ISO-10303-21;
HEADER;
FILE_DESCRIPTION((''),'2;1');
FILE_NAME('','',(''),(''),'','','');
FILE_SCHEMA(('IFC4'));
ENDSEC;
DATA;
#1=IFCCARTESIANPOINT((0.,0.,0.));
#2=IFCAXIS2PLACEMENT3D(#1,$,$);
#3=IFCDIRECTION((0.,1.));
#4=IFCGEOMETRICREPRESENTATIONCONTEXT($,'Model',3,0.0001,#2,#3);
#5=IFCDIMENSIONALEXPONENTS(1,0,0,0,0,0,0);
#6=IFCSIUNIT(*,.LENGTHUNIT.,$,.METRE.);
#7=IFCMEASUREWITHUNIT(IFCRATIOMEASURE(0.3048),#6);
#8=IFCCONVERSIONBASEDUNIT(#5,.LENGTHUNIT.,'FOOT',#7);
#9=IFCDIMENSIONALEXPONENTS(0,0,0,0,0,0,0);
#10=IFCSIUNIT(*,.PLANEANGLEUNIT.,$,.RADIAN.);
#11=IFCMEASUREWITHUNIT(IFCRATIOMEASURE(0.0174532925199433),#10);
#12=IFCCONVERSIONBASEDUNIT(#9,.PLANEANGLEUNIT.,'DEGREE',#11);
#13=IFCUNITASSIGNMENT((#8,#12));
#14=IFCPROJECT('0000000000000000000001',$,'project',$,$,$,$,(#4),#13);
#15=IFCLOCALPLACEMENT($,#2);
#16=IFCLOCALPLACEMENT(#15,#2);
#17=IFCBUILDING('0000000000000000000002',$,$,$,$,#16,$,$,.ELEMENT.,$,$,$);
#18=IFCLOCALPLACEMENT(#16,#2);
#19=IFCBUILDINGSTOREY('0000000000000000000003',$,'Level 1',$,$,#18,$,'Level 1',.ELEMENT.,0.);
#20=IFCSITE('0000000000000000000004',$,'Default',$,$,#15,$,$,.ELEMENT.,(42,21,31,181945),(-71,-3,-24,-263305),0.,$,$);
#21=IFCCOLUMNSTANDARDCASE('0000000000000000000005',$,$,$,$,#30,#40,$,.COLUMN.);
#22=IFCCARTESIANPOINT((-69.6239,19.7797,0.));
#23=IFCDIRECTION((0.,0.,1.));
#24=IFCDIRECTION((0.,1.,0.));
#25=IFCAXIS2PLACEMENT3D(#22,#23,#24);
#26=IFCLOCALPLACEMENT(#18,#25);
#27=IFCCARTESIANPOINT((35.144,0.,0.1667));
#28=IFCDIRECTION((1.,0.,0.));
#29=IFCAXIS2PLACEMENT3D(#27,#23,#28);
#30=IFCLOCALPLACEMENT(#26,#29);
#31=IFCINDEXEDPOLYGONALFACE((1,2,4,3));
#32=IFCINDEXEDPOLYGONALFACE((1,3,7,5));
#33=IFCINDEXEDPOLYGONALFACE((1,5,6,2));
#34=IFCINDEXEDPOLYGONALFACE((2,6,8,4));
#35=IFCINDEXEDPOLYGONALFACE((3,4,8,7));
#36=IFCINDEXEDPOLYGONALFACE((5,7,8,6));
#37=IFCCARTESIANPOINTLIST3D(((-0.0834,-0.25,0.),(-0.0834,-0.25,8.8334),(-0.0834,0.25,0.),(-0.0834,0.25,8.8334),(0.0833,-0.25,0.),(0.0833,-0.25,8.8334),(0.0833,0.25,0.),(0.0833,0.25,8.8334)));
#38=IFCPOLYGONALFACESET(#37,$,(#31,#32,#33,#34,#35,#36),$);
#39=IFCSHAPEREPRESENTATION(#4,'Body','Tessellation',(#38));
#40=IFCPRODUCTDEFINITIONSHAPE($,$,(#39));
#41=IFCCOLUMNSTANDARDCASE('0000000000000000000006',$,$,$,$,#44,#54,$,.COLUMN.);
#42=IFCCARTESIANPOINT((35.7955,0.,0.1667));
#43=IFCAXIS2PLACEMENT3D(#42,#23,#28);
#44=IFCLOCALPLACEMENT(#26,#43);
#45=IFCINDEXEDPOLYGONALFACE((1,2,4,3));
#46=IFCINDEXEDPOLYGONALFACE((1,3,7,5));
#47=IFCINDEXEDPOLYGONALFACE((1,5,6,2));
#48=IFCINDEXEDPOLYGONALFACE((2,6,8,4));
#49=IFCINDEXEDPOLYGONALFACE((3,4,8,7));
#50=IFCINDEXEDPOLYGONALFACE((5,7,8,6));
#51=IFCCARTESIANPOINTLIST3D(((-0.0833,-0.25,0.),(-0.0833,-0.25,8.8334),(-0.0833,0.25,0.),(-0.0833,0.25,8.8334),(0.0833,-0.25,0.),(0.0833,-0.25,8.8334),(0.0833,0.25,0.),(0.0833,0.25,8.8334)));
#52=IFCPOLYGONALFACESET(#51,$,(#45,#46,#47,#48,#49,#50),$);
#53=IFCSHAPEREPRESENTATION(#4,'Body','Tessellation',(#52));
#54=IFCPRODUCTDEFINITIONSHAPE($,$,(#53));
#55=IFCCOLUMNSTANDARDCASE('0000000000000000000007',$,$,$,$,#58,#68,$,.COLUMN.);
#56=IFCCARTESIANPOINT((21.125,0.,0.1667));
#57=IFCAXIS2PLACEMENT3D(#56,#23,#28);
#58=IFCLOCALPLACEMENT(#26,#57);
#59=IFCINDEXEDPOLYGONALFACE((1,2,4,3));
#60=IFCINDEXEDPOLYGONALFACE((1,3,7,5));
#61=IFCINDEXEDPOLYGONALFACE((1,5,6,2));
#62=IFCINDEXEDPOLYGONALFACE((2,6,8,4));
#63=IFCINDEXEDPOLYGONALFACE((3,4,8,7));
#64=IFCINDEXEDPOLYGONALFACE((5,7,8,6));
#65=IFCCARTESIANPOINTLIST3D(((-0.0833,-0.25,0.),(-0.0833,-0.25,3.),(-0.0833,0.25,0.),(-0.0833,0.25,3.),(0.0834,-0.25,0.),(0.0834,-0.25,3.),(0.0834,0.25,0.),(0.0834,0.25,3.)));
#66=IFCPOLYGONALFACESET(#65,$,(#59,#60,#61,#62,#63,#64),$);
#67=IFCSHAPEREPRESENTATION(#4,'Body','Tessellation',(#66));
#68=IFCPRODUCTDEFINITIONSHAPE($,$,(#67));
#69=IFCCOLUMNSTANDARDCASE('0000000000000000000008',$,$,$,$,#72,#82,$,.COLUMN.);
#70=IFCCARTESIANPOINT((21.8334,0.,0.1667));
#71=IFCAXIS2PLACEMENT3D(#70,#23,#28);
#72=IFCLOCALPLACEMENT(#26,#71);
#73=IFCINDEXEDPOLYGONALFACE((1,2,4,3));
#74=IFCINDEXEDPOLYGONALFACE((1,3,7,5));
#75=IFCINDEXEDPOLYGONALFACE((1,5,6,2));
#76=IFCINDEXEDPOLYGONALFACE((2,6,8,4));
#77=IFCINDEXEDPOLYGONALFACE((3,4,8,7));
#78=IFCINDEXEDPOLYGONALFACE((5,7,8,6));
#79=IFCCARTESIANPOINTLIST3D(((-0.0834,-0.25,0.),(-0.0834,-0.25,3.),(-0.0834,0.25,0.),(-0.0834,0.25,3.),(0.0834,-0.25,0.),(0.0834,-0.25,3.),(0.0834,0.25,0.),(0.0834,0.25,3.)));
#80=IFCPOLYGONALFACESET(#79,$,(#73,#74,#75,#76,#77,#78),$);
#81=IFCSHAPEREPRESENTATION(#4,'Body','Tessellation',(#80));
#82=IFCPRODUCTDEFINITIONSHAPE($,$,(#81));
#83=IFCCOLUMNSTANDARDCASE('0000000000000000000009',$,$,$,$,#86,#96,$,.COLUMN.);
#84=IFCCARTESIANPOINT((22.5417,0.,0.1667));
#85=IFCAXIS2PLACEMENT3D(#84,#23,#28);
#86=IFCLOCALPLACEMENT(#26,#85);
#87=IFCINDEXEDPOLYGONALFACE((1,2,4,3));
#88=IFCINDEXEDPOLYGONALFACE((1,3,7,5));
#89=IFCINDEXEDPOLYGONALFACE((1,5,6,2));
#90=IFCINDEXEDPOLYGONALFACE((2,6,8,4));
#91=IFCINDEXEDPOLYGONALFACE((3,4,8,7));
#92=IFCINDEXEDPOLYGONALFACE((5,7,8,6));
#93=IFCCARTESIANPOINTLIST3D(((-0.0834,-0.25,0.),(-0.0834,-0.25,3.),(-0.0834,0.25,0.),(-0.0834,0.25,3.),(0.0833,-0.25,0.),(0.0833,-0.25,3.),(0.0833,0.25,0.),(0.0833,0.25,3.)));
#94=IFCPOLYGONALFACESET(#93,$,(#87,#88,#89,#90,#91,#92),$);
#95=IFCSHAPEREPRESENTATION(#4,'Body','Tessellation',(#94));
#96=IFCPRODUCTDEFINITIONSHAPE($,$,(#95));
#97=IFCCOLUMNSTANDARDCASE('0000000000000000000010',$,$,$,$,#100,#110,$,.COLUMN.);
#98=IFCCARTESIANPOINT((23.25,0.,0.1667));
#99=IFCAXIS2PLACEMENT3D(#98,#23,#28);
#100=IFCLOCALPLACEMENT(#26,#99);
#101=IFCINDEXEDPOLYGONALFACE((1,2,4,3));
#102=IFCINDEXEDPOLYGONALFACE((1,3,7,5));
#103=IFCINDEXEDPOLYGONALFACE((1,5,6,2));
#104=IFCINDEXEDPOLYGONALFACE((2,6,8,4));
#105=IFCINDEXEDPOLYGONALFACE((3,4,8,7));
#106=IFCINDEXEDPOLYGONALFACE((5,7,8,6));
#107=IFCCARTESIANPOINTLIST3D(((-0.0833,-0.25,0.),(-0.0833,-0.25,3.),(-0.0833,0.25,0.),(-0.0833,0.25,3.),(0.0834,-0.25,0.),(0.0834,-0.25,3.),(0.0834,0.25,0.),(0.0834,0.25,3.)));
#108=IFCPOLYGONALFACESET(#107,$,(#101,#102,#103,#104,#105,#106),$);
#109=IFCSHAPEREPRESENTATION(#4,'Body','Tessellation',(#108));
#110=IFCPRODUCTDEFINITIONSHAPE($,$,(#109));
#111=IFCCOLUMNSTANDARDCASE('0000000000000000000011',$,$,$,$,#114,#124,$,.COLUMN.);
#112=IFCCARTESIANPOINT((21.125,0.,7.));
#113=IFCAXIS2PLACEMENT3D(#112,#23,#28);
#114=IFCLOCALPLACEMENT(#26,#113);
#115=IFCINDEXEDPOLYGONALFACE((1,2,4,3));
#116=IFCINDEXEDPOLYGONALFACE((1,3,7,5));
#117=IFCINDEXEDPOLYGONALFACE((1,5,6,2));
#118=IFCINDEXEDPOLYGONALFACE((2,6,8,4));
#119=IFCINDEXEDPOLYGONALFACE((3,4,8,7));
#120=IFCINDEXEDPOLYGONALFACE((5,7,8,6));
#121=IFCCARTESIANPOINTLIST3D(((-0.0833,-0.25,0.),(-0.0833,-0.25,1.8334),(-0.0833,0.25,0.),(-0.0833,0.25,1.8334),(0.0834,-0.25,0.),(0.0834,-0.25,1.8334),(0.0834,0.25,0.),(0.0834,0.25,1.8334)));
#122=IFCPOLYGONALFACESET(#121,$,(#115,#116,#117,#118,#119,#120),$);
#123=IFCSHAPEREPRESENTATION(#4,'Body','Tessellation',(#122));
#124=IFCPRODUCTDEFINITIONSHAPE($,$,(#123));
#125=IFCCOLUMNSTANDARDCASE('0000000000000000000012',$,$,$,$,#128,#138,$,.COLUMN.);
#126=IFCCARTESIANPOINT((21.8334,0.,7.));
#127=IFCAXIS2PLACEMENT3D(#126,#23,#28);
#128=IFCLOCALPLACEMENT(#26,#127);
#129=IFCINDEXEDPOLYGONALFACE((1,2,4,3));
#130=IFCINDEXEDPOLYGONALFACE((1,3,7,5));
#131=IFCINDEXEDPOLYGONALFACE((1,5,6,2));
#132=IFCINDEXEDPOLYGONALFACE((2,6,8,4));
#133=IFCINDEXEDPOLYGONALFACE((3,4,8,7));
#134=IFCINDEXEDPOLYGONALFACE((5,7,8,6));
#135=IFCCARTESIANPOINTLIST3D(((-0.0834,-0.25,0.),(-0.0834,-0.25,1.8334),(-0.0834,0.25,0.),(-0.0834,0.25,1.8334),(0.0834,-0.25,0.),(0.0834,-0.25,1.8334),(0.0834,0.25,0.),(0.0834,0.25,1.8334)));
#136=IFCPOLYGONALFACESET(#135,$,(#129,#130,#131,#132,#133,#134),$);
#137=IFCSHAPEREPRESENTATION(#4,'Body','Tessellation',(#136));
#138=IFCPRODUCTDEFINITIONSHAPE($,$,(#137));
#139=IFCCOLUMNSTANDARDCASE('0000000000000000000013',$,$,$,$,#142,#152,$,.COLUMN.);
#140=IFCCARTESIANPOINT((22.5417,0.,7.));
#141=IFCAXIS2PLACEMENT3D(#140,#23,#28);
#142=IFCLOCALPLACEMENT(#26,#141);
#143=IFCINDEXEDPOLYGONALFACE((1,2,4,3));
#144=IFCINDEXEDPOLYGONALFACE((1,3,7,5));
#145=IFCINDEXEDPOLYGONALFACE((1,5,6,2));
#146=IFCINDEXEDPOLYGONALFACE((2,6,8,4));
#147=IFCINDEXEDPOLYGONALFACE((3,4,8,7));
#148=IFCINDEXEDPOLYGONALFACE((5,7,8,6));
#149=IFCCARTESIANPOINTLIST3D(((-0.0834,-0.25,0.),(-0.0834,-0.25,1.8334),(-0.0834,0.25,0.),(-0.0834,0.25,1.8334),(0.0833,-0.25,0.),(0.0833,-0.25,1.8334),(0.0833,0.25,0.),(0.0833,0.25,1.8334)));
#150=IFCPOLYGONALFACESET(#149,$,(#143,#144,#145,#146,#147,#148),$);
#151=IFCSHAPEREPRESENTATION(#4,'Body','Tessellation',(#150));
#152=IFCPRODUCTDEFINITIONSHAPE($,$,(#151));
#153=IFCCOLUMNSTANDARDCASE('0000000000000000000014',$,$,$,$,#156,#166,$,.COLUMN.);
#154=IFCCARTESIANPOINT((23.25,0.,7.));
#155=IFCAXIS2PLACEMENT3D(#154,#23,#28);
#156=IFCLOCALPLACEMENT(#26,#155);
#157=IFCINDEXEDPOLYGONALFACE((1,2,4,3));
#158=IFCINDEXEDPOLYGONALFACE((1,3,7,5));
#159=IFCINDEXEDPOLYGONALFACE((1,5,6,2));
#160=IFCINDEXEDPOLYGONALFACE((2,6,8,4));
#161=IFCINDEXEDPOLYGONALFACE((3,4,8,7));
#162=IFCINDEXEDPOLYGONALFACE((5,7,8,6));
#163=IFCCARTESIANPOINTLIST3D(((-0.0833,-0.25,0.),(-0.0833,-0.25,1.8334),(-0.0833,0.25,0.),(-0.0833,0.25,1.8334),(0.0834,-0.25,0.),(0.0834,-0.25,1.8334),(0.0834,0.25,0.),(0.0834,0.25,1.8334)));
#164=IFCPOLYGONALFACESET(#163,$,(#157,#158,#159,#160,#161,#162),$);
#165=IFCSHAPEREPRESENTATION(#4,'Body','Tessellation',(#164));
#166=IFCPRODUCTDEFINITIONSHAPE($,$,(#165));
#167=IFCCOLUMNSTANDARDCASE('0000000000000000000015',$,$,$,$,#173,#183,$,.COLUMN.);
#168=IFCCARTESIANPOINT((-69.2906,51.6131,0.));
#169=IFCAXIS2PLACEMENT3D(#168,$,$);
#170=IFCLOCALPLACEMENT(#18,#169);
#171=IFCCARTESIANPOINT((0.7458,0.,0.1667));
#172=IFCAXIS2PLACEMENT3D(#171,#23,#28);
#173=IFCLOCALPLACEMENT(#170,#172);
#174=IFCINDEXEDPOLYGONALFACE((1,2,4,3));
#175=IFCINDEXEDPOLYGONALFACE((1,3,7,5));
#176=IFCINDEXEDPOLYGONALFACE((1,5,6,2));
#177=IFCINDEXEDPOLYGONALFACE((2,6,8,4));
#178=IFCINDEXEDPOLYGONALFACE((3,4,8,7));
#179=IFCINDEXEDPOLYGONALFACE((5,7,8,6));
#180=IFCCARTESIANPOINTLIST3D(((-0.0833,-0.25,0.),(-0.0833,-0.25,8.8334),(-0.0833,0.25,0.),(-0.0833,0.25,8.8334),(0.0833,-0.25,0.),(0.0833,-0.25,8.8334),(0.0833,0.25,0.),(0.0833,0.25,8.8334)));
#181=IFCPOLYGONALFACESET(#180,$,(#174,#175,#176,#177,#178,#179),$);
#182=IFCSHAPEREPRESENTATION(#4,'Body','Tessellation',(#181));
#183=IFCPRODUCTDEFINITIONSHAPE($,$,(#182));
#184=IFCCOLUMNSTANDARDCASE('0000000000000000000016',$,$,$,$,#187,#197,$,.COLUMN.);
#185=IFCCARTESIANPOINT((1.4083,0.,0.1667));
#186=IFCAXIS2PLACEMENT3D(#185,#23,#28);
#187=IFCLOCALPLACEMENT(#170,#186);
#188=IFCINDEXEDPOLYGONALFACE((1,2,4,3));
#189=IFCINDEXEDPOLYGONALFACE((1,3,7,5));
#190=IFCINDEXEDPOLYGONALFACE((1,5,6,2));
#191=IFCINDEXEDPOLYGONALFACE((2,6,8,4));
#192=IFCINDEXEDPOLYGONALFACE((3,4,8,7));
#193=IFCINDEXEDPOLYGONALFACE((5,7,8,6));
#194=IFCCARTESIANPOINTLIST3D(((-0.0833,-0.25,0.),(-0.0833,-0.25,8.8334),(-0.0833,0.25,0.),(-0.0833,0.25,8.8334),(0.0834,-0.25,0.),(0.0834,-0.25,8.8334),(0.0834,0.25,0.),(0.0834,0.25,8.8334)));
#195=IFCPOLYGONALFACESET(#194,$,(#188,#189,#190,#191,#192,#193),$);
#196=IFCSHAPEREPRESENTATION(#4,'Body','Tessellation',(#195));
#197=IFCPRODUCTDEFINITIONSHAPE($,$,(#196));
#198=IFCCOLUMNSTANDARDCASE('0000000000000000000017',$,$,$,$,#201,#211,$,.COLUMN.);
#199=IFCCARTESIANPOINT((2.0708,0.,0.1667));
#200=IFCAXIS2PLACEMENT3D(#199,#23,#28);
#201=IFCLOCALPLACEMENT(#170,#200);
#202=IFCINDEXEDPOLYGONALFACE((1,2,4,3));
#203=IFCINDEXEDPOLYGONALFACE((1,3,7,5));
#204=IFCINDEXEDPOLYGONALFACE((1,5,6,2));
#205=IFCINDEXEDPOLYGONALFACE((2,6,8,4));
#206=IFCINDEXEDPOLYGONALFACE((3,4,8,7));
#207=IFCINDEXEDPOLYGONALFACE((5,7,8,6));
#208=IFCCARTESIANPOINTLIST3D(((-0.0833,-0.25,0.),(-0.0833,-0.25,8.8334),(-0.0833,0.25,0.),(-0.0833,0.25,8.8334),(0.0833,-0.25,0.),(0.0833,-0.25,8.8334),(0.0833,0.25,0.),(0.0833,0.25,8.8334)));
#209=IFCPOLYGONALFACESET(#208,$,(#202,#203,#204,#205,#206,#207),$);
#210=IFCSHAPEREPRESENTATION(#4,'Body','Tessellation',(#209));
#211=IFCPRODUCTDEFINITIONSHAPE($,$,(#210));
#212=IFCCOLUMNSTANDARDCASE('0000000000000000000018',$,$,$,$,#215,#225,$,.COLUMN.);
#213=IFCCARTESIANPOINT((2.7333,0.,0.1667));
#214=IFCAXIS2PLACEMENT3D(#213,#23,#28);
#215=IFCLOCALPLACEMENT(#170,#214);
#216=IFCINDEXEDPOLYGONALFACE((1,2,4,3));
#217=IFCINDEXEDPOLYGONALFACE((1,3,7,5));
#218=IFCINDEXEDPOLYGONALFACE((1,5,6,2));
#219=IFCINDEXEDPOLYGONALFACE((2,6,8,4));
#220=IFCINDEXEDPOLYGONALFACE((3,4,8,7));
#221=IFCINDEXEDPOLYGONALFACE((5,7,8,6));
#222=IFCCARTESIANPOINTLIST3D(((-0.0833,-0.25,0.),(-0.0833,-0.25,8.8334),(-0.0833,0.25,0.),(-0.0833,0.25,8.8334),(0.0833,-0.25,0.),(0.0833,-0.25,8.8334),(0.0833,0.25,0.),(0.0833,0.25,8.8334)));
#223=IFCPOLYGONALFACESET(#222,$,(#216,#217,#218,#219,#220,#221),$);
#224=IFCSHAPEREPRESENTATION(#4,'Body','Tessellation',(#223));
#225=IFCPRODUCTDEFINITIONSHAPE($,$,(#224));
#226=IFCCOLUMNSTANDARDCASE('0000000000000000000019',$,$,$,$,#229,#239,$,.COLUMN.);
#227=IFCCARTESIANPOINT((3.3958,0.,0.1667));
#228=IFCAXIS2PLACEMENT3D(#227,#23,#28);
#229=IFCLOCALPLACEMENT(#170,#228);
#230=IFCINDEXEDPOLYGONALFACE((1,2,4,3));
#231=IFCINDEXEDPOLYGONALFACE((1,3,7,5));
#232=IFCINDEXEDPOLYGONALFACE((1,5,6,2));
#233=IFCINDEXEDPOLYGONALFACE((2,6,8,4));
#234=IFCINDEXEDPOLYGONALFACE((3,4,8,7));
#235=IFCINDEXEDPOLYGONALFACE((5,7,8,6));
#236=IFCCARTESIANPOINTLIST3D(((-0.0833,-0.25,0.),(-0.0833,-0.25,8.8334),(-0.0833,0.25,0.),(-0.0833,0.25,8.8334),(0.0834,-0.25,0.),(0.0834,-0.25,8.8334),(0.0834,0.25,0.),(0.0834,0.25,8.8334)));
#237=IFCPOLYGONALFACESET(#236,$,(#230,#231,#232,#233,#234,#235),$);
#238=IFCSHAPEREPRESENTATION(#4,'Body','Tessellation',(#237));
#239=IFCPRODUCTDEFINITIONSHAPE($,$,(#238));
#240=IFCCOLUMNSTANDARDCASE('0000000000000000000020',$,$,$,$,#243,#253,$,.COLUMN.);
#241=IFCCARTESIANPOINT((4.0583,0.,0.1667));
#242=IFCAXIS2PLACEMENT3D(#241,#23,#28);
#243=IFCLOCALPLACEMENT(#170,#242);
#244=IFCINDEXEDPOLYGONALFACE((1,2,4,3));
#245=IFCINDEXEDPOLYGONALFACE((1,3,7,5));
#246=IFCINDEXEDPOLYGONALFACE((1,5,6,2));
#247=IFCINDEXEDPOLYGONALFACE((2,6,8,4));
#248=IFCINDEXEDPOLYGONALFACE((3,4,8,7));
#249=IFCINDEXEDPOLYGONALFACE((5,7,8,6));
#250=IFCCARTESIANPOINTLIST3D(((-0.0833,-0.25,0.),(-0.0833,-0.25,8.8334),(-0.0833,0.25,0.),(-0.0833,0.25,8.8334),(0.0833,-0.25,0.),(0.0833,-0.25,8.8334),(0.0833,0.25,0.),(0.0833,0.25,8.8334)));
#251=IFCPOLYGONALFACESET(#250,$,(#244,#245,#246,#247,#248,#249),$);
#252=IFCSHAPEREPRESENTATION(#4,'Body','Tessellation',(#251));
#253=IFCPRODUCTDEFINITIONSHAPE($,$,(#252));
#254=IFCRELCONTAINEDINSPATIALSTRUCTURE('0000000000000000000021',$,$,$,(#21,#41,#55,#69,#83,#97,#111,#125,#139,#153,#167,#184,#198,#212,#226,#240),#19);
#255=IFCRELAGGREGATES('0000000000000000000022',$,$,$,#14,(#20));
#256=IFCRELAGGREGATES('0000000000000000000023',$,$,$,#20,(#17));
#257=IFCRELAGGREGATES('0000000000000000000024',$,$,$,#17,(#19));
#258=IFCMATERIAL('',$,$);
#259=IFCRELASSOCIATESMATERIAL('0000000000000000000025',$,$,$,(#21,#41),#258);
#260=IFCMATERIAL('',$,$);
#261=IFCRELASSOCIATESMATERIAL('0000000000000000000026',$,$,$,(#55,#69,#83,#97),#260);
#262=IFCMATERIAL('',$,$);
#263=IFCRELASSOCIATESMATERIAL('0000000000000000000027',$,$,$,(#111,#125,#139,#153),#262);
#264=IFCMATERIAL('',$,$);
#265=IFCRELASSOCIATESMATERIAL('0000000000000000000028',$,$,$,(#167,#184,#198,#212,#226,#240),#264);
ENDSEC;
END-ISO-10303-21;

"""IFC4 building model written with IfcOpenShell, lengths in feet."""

from ifc_helpers import new_model, entity, si_unit, converted_unit, direction, frame, origin, place, context, project, spatial, rectangle, extrude, material, element, save


model = new_model("IFC4")

# Units and contexts
model_context = context("Model", 3, precision=0.0001, world=origin(), true_north=direction((0.0, 1.0)))
ifc_project = project(units=[converted_unit("LENGTHUNIT", "FOOT", entity("IfcRatioMeasure", 0.3048), si_unit("LENGTHUNIT", "METRE"), dimensions=[1, 0, 0, 0, 0, 0, 0]), converted_unit("PLANEANGLEUNIT", "DEGREE", entity("IfcRatioMeasure", 0.0174532925199433), si_unit("PLANEANGLEUNIT", "RADIAN"), dimensions=[0, 0, 0, 0, 0, 0, 0])], contexts=[model_context])

# Site, building, storey
site_placement = place(None, origin())
site = spatial("IfcSite", under=ifc_project, at=site_placement, Name="Default", CompositionType="ELEMENT", RefLatitude=(42, 21, 31, 181945), RefLongitude=(-71, -3, -24, -263305), RefElevation=0.0)
building_placement = place(site_placement, origin())
building = spatial("IfcBuilding", under=site, at=building_placement, CompositionType="ELEMENT")
storey_placement = place(building_placement, origin())
storey = spatial("IfcBuildingStorey", under=building, at=storey_placement, Name="Level 1", LongName="Level 1", CompositionType="ELEMENT", Elevation=0.0)

# Columns
ifc_material_1 = material(Name="")
placement_1 = place(storey_placement, frame((-69.6239, 19.7797, 0.0), z_axis=(0.0, 0.0, 1.0), x_axis=(0.0, 1.0, 0.0)))
for number, where, z_axis, x_axis in (
    (1, (35.144, 0.0, 0.1667), (0.0, 0.0, 1.0), (1.0, 0.0, 0.0)),
    (2, (35.7955, 0.0, 0.1667), (0.0, 0.0, 1.0), (1.0, 0.0, 0.0)),
):
    element("IfcColumnStandardCase", number, at=place(placement_1, frame(where, z_axis=z_axis, x_axis=x_axis)), inside=storey, material=ifc_material_1, PredefinedType="COLUMN", context=model_context, shape_type="SweptSolid", body=[
        extrude(rectangle(XDim=0.1667, YDim=0.5), origin(), (0.0, 0.0, 1.0), 8.8334),
    ])
ifc_material_2 = material(Name="")
for number, where, z_axis, x_axis in (
    (3, (21.125, 0.0, 0.1667), (0.0, 0.0, 1.0), (1.0, 0.0, 0.0)),
    (4, (21.8334, 0.0, 0.1667), (0.0, 0.0, 1.0), (1.0, 0.0, 0.0)),
    (5, (22.5417, 0.0, 0.1667), (0.0, 0.0, 1.0), (1.0, 0.0, 0.0)),
    (6, (23.25, 0.0, 0.1667), (0.0, 0.0, 1.0), (1.0, 0.0, 0.0)),
):
    element("IfcColumnStandardCase", number, at=place(placement_1, frame(where, z_axis=z_axis, x_axis=x_axis)), inside=storey, material=ifc_material_2, PredefinedType="COLUMN", context=model_context, shape_type="SweptSolid", body=[
        extrude(rectangle(XDim=0.1667, YDim=0.5), origin(), (0.0, 0.0, 1.0), 3.0),
    ])
ifc_material_3 = material(Name="")
for number, where, z_axis, x_axis in (
    (7, (21.125, 0.0, 7.0), (0.0, 0.0, 1.0), (1.0, 0.0, 0.0)),
    (8, (21.8334, 0.0, 7.0), (0.0, 0.0, 1.0), (1.0, 0.0, 0.0)),
    (9, (22.5417, 0.0, 7.0), (0.0, 0.0, 1.0), (1.0, 0.0, 0.0)),
    (10, (23.25, 0.0, 7.0), (0.0, 0.0, 1.0), (1.0, 0.0, 0.0)),
):
    element("IfcColumnStandardCase", number, at=place(placement_1, frame(where, z_axis=z_axis, x_axis=x_axis)), inside=storey, material=ifc_material_3, PredefinedType="COLUMN", context=model_context, shape_type="SweptSolid", body=[
        extrude(rectangle(XDim=0.1667, YDim=0.5), origin(), (0.0, 0.0, 1.0), 1.8334),
    ])
ifc_material_4 = material(Name="")
placement_2 = place(storey_placement, frame((-69.2906, 51.6131, 0.0)))
for number, where, z_axis, x_axis in (
    (11, (0.7458, 0.0, 0.1667), (0.0, 0.0, 1.0), (1.0, 0.0, 0.0)),
    (12, (1.4083, 0.0, 0.1667), (0.0, 0.0, 1.0), (1.0, 0.0, 0.0)),
    (13, (2.0708, 0.0, 0.1667), (0.0, 0.0, 1.0), (1.0, 0.0, 0.0)),
    (14, (2.7333, 0.0, 0.1667), (0.0, 0.0, 1.0), (1.0, 0.0, 0.0)),
    (15, (3.3958, 0.0, 0.1667), (0.0, 0.0, 1.0), (1.0, 0.0, 0.0)),
    (16, (4.0583, 0.0, 0.1667), (0.0, 0.0, 1.0), (1.0, 0.0, 0.0)),
):
    element("IfcColumnStandardCase", number, at=place(placement_2, frame(where, z_axis=z_axis, x_axis=x_axis)), inside=storey, material=ifc_material_4, PredefinedType="COLUMN", context=model_context, shape_type="SweptSolid", body=[
        extrude(rectangle(XDim=0.1667, YDim=0.5), origin(), (0.0, 0.0, 1.0), 8.8334),
    ])

save(model, "model.ifc")
